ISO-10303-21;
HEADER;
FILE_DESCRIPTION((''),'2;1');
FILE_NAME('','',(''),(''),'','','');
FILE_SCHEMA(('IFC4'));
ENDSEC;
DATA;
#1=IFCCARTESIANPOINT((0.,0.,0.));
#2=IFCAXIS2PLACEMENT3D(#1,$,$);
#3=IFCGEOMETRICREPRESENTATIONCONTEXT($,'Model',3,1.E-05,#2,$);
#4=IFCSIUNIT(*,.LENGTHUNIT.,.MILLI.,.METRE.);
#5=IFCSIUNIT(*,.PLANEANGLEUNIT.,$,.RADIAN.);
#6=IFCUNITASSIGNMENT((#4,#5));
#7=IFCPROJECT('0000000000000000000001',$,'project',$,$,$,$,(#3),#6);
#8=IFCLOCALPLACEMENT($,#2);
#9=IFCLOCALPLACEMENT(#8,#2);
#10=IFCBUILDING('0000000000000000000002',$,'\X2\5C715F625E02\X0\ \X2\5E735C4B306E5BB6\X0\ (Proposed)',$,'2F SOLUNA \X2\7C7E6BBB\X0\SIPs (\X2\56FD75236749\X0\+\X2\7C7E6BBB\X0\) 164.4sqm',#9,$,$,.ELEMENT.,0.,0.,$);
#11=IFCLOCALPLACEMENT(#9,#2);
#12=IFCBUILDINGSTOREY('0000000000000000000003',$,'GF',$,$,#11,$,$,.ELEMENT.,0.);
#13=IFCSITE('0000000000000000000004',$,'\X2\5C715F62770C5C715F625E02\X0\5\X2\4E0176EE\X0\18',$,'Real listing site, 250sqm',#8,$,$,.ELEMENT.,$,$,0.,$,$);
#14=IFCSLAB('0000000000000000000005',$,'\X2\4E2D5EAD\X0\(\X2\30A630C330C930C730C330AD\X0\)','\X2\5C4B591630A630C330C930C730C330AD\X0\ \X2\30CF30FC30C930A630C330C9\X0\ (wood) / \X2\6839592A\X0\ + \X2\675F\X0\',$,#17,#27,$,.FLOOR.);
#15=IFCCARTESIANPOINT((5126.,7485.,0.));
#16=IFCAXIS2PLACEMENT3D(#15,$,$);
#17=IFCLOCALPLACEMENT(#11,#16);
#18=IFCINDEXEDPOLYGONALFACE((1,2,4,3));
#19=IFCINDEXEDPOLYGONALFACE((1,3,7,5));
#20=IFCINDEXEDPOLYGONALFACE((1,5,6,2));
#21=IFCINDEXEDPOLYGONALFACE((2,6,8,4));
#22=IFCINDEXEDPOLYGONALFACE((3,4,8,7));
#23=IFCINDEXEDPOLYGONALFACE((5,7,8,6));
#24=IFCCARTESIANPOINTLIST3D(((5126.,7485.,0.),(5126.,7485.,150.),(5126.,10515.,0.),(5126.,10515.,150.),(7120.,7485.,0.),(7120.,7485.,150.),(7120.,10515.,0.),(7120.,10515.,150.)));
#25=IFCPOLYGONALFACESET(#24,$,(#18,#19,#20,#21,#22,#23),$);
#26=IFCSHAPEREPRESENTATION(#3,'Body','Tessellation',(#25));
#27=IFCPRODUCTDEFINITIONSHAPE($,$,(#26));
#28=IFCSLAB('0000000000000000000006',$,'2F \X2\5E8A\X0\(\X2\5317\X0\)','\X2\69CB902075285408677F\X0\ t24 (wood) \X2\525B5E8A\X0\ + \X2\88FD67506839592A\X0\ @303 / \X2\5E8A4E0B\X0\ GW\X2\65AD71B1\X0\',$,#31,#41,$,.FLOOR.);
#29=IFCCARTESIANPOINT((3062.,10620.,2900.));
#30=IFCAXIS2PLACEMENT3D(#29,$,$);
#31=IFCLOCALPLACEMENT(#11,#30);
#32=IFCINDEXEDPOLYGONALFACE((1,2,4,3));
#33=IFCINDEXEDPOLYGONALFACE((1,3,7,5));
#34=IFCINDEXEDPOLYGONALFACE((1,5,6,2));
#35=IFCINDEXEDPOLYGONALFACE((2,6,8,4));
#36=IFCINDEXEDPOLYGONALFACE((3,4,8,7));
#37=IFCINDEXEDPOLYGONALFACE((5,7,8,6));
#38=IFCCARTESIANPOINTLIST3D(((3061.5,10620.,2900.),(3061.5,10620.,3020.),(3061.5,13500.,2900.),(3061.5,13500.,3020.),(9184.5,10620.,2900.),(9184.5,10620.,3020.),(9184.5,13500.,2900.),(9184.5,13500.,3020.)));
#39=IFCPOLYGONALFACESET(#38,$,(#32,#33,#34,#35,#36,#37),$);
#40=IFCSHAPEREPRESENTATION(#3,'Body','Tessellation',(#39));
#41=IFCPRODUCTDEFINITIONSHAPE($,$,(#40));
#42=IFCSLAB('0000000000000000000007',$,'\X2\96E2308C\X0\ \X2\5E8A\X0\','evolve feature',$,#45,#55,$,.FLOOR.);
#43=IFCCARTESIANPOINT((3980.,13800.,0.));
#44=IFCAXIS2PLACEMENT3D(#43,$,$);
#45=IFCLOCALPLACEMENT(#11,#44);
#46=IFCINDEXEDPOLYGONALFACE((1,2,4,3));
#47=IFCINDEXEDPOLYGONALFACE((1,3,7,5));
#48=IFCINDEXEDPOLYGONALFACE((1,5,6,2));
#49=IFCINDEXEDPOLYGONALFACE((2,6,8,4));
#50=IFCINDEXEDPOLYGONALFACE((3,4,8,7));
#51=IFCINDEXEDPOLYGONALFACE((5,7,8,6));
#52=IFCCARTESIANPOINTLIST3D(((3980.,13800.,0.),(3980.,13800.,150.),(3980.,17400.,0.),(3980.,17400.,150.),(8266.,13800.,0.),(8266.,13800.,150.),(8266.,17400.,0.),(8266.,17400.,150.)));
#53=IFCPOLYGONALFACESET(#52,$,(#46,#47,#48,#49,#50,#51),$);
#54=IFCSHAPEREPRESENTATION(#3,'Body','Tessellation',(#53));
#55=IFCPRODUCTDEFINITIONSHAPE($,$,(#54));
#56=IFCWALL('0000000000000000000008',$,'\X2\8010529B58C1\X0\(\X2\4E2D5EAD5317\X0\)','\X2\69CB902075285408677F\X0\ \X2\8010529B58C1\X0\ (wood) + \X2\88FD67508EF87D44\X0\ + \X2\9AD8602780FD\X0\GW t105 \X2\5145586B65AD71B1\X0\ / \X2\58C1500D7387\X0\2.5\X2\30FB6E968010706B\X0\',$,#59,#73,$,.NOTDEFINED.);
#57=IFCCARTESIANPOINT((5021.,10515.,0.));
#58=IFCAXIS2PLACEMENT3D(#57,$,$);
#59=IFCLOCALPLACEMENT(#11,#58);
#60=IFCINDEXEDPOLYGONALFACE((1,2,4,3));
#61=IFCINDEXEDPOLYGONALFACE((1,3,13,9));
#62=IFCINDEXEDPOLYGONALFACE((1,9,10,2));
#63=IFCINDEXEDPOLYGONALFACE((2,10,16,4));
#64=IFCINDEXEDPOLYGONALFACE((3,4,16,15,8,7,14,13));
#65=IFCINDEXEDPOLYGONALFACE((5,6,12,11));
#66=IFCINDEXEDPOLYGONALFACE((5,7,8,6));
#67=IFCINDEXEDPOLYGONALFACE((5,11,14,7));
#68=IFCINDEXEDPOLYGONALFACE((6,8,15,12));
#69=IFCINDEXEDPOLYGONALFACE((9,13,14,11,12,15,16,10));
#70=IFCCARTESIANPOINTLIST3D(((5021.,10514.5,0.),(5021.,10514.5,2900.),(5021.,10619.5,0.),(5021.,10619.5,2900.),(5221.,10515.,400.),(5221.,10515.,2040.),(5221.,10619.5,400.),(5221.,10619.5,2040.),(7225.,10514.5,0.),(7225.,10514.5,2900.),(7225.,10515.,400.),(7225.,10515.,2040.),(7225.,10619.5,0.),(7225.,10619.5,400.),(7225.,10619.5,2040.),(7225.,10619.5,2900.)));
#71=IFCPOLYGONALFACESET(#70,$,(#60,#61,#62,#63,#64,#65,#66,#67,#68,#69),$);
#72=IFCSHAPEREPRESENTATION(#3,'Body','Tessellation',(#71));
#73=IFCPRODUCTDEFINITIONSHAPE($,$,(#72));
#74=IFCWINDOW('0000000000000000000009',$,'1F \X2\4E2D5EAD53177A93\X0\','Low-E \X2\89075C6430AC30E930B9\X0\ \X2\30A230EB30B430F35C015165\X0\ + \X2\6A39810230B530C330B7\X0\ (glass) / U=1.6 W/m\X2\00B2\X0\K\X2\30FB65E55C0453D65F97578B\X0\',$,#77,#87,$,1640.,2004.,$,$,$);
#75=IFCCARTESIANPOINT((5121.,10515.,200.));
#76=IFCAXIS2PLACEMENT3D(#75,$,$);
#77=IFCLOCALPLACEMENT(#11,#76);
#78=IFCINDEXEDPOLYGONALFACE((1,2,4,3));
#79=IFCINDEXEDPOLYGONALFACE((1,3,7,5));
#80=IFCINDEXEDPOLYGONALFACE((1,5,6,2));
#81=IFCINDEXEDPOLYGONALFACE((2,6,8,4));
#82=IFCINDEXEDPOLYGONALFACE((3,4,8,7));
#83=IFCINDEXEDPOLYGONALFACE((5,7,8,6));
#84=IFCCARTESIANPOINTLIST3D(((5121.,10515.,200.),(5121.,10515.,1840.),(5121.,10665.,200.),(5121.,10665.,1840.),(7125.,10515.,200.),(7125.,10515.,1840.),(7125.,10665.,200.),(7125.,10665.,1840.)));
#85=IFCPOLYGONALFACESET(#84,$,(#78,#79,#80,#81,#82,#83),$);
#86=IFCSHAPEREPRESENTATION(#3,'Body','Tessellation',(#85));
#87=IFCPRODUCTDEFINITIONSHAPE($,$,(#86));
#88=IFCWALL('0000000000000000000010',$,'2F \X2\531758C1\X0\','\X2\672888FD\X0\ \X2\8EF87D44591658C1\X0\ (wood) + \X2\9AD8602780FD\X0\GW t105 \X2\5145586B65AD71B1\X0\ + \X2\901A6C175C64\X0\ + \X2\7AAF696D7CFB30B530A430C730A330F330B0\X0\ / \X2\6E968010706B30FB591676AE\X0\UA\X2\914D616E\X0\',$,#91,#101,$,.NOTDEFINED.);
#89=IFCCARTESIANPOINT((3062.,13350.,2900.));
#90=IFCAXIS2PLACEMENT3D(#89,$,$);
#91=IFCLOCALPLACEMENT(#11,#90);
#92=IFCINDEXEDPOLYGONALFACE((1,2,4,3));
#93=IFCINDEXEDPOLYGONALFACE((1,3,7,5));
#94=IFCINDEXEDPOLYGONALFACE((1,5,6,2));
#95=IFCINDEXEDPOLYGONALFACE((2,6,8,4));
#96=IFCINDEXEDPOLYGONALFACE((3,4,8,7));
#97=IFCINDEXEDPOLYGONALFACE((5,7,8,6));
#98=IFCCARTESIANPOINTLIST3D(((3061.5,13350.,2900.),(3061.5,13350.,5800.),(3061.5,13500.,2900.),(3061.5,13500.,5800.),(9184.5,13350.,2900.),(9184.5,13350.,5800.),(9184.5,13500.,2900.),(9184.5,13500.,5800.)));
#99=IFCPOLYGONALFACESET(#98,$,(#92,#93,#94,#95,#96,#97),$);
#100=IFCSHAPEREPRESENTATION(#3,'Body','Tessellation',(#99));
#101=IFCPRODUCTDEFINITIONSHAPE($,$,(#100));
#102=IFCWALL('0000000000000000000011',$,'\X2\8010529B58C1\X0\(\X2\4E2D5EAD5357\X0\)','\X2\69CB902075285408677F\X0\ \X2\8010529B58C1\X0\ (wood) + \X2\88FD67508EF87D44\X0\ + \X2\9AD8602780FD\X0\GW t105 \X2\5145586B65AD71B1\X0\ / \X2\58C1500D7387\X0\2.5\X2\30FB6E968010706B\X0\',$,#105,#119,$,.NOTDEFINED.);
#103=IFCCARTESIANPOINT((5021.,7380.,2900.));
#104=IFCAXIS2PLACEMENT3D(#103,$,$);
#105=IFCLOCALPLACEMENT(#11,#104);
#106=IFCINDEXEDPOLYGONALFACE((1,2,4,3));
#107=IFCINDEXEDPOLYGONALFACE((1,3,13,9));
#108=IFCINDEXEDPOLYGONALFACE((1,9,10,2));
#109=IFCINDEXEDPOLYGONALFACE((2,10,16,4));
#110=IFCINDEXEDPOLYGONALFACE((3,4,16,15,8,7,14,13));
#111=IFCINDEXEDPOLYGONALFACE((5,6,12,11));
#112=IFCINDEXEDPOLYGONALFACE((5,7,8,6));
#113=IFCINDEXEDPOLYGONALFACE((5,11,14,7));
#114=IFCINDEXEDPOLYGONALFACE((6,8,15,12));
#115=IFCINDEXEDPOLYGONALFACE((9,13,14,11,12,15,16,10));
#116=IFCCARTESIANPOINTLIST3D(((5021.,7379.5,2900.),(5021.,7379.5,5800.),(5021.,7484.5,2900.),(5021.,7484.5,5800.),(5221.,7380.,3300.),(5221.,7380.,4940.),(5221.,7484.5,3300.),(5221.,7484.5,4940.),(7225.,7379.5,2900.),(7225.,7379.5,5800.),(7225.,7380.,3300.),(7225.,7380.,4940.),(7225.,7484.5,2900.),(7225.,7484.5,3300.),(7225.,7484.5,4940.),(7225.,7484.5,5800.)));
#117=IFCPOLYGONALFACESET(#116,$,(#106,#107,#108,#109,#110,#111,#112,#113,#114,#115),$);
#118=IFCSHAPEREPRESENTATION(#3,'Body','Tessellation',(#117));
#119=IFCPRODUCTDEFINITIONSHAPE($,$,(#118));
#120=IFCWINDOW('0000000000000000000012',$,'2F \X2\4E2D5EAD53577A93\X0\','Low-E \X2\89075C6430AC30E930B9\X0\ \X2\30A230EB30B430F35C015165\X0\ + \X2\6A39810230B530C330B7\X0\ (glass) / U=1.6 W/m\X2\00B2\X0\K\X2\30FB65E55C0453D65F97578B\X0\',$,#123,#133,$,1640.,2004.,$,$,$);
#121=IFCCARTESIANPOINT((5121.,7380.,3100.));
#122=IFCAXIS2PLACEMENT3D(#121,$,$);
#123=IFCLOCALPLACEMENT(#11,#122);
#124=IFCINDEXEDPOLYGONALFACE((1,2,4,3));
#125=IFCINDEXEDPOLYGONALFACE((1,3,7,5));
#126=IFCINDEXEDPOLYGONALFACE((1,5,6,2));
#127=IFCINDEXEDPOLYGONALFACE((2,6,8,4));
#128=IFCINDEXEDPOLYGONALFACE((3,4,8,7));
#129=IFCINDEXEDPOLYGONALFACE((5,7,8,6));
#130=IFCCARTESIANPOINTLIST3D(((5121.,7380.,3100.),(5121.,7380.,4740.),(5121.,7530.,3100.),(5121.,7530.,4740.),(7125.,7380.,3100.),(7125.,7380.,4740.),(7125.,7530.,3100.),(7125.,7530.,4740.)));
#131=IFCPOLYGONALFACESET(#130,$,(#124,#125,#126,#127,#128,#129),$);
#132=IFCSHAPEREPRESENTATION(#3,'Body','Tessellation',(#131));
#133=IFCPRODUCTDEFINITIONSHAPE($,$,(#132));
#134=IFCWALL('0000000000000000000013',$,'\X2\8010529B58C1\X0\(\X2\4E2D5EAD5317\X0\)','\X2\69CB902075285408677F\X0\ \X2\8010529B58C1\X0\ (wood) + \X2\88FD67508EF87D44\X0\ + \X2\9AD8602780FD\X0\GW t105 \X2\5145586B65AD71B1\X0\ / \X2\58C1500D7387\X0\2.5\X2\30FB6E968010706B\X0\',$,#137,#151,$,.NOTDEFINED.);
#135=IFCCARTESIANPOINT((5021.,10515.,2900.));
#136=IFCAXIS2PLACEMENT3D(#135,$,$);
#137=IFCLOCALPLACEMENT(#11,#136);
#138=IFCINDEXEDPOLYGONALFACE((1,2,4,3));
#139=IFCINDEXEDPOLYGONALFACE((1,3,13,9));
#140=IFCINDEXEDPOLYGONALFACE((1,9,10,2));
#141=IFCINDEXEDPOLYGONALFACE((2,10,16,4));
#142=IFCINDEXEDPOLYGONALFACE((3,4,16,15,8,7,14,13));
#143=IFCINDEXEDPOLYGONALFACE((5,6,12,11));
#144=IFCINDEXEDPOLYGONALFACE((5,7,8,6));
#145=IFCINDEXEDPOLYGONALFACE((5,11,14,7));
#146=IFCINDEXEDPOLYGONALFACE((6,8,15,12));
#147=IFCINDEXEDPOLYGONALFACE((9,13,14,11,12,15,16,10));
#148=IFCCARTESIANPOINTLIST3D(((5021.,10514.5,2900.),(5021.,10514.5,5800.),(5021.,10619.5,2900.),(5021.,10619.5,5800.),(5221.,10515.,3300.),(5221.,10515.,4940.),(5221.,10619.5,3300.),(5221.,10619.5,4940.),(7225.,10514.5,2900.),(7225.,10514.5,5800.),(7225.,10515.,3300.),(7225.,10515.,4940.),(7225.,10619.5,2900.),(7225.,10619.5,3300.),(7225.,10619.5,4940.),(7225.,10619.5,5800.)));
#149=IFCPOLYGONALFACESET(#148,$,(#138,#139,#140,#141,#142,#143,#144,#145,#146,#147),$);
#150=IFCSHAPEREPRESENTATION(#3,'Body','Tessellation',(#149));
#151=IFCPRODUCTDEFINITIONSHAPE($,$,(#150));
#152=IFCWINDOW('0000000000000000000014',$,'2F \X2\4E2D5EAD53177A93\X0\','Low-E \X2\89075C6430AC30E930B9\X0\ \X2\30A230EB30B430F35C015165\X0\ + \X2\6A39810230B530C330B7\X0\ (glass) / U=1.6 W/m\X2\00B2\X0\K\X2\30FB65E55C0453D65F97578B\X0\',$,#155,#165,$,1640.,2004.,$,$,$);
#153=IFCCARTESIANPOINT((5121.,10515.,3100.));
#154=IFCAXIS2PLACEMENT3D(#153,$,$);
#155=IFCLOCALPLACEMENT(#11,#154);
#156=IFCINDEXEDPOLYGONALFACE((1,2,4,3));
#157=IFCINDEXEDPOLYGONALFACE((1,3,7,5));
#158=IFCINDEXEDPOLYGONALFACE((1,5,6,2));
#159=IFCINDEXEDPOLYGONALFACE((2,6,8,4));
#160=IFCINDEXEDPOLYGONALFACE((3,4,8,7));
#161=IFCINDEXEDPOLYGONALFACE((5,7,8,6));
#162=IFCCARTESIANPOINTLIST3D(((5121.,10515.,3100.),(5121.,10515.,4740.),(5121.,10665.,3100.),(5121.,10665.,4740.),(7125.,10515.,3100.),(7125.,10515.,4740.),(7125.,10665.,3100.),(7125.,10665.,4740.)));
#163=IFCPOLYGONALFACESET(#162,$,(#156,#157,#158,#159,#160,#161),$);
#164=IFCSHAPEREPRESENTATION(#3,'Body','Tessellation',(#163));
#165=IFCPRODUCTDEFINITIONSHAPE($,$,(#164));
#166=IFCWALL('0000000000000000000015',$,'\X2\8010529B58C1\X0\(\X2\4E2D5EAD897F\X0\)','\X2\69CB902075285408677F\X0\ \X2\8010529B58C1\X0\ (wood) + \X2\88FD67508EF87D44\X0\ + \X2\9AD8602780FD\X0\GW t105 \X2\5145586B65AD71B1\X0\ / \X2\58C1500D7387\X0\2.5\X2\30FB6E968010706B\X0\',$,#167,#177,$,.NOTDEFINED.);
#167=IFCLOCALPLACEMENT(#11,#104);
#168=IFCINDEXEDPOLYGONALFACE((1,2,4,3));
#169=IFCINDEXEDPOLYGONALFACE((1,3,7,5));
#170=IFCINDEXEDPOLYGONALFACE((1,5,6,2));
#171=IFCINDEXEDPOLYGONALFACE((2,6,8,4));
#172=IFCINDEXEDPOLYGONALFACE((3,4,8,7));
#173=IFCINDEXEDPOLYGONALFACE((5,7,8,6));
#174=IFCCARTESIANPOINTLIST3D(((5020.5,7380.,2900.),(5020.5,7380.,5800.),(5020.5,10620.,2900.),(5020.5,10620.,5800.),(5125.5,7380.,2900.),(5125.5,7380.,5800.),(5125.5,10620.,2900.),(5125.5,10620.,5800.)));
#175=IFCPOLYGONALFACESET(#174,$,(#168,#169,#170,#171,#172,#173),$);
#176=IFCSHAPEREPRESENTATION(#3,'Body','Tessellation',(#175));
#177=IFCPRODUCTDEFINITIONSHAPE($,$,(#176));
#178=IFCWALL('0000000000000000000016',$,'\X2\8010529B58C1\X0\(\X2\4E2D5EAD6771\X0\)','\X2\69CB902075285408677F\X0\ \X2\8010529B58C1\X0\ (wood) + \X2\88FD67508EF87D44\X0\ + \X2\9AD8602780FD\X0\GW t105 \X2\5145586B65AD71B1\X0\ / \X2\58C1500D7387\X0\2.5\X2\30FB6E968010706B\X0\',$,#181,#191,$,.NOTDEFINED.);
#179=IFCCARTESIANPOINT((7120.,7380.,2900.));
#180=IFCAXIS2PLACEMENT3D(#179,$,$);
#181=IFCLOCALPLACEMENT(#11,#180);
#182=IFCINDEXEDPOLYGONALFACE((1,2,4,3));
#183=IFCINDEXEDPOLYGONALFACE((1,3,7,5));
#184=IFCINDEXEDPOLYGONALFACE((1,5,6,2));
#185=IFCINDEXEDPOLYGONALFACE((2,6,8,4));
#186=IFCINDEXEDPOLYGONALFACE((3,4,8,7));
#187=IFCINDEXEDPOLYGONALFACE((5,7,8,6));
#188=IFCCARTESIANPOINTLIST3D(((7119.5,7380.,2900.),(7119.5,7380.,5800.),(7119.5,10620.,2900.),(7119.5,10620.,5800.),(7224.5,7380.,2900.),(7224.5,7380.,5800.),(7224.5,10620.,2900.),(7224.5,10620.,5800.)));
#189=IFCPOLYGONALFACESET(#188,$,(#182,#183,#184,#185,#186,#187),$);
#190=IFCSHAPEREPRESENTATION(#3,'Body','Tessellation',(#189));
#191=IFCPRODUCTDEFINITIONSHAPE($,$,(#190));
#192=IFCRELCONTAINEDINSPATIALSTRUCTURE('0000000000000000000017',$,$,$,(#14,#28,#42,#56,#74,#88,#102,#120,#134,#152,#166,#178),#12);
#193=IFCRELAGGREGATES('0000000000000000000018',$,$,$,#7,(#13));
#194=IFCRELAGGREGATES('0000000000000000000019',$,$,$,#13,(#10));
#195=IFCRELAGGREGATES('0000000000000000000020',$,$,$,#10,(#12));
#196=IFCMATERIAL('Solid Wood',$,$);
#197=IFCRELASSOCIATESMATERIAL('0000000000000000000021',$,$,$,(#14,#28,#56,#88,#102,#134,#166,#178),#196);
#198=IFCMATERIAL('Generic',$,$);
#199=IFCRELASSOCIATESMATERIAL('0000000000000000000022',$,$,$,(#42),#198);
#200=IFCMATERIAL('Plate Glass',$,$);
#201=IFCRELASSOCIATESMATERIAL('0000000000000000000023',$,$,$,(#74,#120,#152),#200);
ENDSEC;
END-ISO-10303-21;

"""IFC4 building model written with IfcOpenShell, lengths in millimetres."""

from ifc_helpers import new_model, si_unit, frame, frame_2d, origin, place, context, project, spatial, rectangle, extrude, material, element, fill, save


model = new_model("IFC4")

# Units and contexts
model_context = context("Model", 3, precision=1e-05, world=origin())
ifc_project = project(units=[si_unit("LENGTHUNIT", "METRE", prefix="MILLI"), si_unit("PLANEANGLEUNIT", "RADIAN")], contexts=[model_context])

# Site, building, storey
site_placement = place(None, origin())
site = spatial("IfcSite", under=ifc_project, at=site_placement, Name="山形県山形市5丁目18", ObjectType="Real listing site, 250sqm", CompositionType="ELEMENT", RefElevation=0.0)
building_placement = place(site_placement, origin())
building = spatial("IfcBuilding", under=site, at=building_placement, Name="山形市 平屋の家 (Proposed)", ObjectType="2F SOLUNA 籾殻SIPs (国産杉+籾殻) 164.4sqm", CompositionType="ELEMENT", ElevationOfRefHeight=0.0, ElevationOfTerrain=0.0)
storey_placement = place(building_placement, origin())
storey = spatial("IfcBuildingStorey", under=building, at=storey_placement, Name="GF", CompositionType="ELEMENT", Elevation=0.0)

# Slabs
ifc_material_1 = material(Name="Solid Wood")
slab_1_placement = place(storey_placement, frame((5126.0, 7485.0, 0.0)))
element("IfcSlab", 1, at=slab_1_placement, inside=storey, material=ifc_material_1, Name="中庭(ウッドデッキ)", Description="屋外ウッドデッキ ハードウッド (wood) / 根太 + 束", PredefinedType="FLOOR", context=model_context, shape_type="SweptSolid", body=[
    extrude(rectangle(XDim=1994.0, YDim=3030.0, at=frame_2d((997.0, 1515.0))), frame((5126.0, 7485.0, 0.0)), (0.0, 0.0, 1.0), 150.0),
])
slab_2_placement = place(storey_placement, frame((3062.0, 10620.0, 2900.0)))
element("IfcSlab", 2, at=slab_2_placement, inside=storey, material=ifc_material_1, Name="2F 床(北)", Description="構造用合板 t24 (wood) 剛床 + 製材根太 @303 / 床下 GW断熱", PredefinedType="FLOOR", context=model_context, shape_type="SweptSolid", body=[
    extrude(rectangle(XDim=6123.0, YDim=2880.0, at=frame_2d((3061.0, 1440.0))), frame((3062.0, 10620.0, 2900.0)), (0.0, 0.0, 1.0), 120.0),
])
ifc_material_2 = material(Name="Generic")
slab_3_placement = place(storey_placement, frame((3980.0, 13800.0, 0.0)))
element("IfcSlab", 3, at=slab_3_placement, inside=storey, material=ifc_material_2, Name="離れ 床", Description="evolve feature", PredefinedType="FLOOR", context=model_context, shape_type="SweptSolid", body=[
    extrude(rectangle(XDim=4286.0, YDim=3600.0, at=frame_2d((2143.0, 1800.0))), frame((3980.0, 13800.0, 0.0)), (0.0, 0.0, 1.0), 150.0),
])

# Wall, opening, window
wall_1_placement = place(storey_placement, frame((5021.0, 10515.0, 0.0)))
wall_1 = element("IfcWall", 4, at=wall_1_placement, inside=storey, material=ifc_material_1, Name="耐力壁(中庭北)", Description="構造用合板 耐力壁 (wood) + 製材軸組 + 高性能GW t105 充填断熱 / 壁倍率2.5・準耐火", PredefinedType="NOTDEFINED", context=model_context, shape_type="SweptSolid", body=[
    extrude(rectangle(XDim=2204.0, YDim=105.0, at=frame_2d((1102.0, 52.0))), frame((5021.0, 10515.0, 0.0)), (0.0, 0.0, 1.0), 2900.0),
])
opening_1_placement = place(storey_placement, frame((5121.0, 10515.0, 200.0)))
opening_1 = element("IfcOpeningElement", 5, at=opening_1_placement, cuts=wall_1, PredefinedType="NOTDEFINED", context=model_context, shape_type="SweptSolid", body=[
    extrude(rectangle(XDim=2004.0, YDim=150.0, at=frame_2d((1002.0, 75.0))), frame((5121.0, 10515.0, 200.0)), (0.0, 0.0, 1.0), 1640.0),
])
ifc_material_3 = material(Name="Plate Glass")
window_1_placement = place(storey_placement, frame((5121.0, 10515.0, 200.0)))
window_1 = element("IfcWindow", 6, at=window_1_placement, inside=storey, material=ifc_material_3, Name="1F 中庭北窓", Description="Low-E 複層ガラス アルゴン封入 + 樹脂サッシ (glass) / U=1.6 W/m²K・日射取得型", OverallHeight=1640.0, OverallWidth=2004.0, context=model_context, shape_type="SweptSolid", body=[
    extrude(rectangle(XDim=2004.0, YDim=150.0, at=frame_2d((1002.0, 75.0))), frame((5121.0, 10515.0, 200.0)), (0.0, 0.0, 1.0), 1640.0),
])
fill(opening_1, window_1)

# Wall
wall_2_placement = place(storey_placement, frame((3062.0, 13350.0, 2900.0)))
element("IfcWall", 7, at=wall_2_placement, inside=storey, material=ifc_material_1, Name="2F 北壁", Description="木製 軸組外壁 (wood) + 高性能GW t105 充填断熱 + 通気層 + 窯業系サイディング / 準耐火・外皮UA配慮", PredefinedType="NOTDEFINED", context=model_context, shape_type="SweptSolid", body=[
    extrude(rectangle(XDim=6123.0, YDim=150.0, at=frame_2d((3061.0, 75.0))), frame((3062.0, 13350.0, 2900.0)), (0.0, 0.0, 1.0), 2900.0),
])

# Walls, openings, windows
wall_3_placement = place(storey_placement, frame((5021.0, 7380.0, 2900.0)))
wall_3 = element("IfcWall", 8, at=wall_3_placement, inside=storey, material=ifc_material_1, Name="耐力壁(中庭南)", Description="構造用合板 耐力壁 (wood) + 製材軸組 + 高性能GW t105 充填断熱 / 壁倍率2.5・準耐火", PredefinedType="NOTDEFINED", context=model_context, shape_type="SweptSolid", body=[
    extrude(rectangle(XDim=2204.0, YDim=105.0, at=frame_2d((1102.0, 52.0))), frame((5021.0, 7380.0, 2900.0)), (0.0, 0.0, 1.0), 2900.0),
])
opening_2_placement = place(storey_placement, frame((5121.0, 7380.0, 3100.0)))
opening_2 = element("IfcOpeningElement", 9, at=opening_2_placement, cuts=wall_3, PredefinedType="NOTDEFINED", context=model_context, shape_type="SweptSolid", body=[
    extrude(rectangle(XDim=2004.0, YDim=150.0, at=frame_2d((1002.0, 75.0))), frame((5121.0, 7380.0, 3100.0)), (0.0, 0.0, 1.0), 1640.0),
])
window_2_placement = place(storey_placement, frame((5121.0, 7380.0, 3100.0)))
window_2 = element("IfcWindow", 10, at=window_2_placement, inside=storey, material=ifc_material_3, Name="2F 中庭南窓", Description="Low-E 複層ガラス アルゴン封入 + 樹脂サッシ (glass) / U=1.6 W/m²K・日射取得型", OverallHeight=1640.0, OverallWidth=2004.0, context=model_context, shape_type="SweptSolid", body=[
    extrude(rectangle(XDim=2004.0, YDim=150.0, at=frame_2d((1002.0, 75.0))), frame((5121.0, 7380.0, 3100.0)), (0.0, 0.0, 1.0), 1640.0),
])
fill(opening_2, window_2)
wall_4_placement = place(storey_placement, frame((5021.0, 10515.0, 2900.0)))
wall_4 = element("IfcWall", 11, at=wall_4_placement, inside=storey, material=ifc_material_1, Name="耐力壁(中庭北)", Description="構造用合板 耐力壁 (wood) + 製材軸組 + 高性能GW t105 充填断熱 / 壁倍率2.5・準耐火", PredefinedType="NOTDEFINED", context=model_context, shape_type="SweptSolid", body=[
    extrude(rectangle(XDim=2204.0, YDim=105.0, at=frame_2d((1102.0, 52.0))), frame((5021.0, 10515.0, 2900.0)), (0.0, 0.0, 1.0), 2900.0),
])
opening_3_placement = place(storey_placement, frame((5121.0, 10515.0, 3100.0)))
opening_3 = element("IfcOpeningElement", 12, at=opening_3_placement, cuts=wall_4, PredefinedType="NOTDEFINED", context=model_context, shape_type="SweptSolid", body=[
    extrude(rectangle(XDim=2004.0, YDim=150.0, at=frame_2d((1002.0, 75.0))), frame((5121.0, 10515.0, 3100.0)), (0.0, 0.0, 1.0), 1640.0),
])
window_3_placement = place(storey_placement, frame((5121.0, 10515.0, 3100.0)))
window_3 = element("IfcWindow", 13, at=window_3_placement, inside=storey, material=ifc_material_3, Name="2F 中庭北窓", Description="Low-E 複層ガラス アルゴン封入 + 樹脂サッシ (glass) / U=1.6 W/m²K・日射取得型", OverallHeight=1640.0, OverallWidth=2004.0, context=model_context, shape_type="SweptSolid", body=[
    extrude(rectangle(XDim=2004.0, YDim=150.0, at=frame_2d((1002.0, 75.0))), frame((5121.0, 10515.0, 3100.0)), (0.0, 0.0, 1.0), 1640.0),
])
fill(opening_3, window_3)

# Walls
wall_5_placement = place(storey_placement, frame((5021.0, 7380.0, 2900.0)))
element("IfcWall", 14, at=wall_5_placement, inside=storey, material=ifc_material_1, Name="耐力壁(中庭西)", Description="構造用合板 耐力壁 (wood) + 製材軸組 + 高性能GW t105 充填断熱 / 壁倍率2.5・準耐火", PredefinedType="NOTDEFINED", context=model_context, shape_type="SweptSolid", body=[
    extrude(rectangle(XDim=105.0, YDim=3240.0, at=frame_2d((52.0, 1620.0))), frame((5021.0, 7380.0, 2900.0)), (0.0, 0.0, 1.0), 2900.0),
])
wall_6_placement = place(storey_placement, frame((7120.0, 7380.0, 2900.0)))
element("IfcWall", 15, at=wall_6_placement, inside=storey, material=ifc_material_1, Name="耐力壁(中庭東)", Description="構造用合板 耐力壁 (wood) + 製材軸組 + 高性能GW t105 充填断熱 / 壁倍率2.5・準耐火", PredefinedType="NOTDEFINED", context=model_context, shape_type="SweptSolid", body=[
    extrude(rectangle(XDim=105.0, YDim=3240.0, at=frame_2d((52.0, 1620.0))), frame((7120.0, 7380.0, 2900.0)), (0.0, 0.0, 1.0), 2900.0),
])

save(model, "model.ifc")
